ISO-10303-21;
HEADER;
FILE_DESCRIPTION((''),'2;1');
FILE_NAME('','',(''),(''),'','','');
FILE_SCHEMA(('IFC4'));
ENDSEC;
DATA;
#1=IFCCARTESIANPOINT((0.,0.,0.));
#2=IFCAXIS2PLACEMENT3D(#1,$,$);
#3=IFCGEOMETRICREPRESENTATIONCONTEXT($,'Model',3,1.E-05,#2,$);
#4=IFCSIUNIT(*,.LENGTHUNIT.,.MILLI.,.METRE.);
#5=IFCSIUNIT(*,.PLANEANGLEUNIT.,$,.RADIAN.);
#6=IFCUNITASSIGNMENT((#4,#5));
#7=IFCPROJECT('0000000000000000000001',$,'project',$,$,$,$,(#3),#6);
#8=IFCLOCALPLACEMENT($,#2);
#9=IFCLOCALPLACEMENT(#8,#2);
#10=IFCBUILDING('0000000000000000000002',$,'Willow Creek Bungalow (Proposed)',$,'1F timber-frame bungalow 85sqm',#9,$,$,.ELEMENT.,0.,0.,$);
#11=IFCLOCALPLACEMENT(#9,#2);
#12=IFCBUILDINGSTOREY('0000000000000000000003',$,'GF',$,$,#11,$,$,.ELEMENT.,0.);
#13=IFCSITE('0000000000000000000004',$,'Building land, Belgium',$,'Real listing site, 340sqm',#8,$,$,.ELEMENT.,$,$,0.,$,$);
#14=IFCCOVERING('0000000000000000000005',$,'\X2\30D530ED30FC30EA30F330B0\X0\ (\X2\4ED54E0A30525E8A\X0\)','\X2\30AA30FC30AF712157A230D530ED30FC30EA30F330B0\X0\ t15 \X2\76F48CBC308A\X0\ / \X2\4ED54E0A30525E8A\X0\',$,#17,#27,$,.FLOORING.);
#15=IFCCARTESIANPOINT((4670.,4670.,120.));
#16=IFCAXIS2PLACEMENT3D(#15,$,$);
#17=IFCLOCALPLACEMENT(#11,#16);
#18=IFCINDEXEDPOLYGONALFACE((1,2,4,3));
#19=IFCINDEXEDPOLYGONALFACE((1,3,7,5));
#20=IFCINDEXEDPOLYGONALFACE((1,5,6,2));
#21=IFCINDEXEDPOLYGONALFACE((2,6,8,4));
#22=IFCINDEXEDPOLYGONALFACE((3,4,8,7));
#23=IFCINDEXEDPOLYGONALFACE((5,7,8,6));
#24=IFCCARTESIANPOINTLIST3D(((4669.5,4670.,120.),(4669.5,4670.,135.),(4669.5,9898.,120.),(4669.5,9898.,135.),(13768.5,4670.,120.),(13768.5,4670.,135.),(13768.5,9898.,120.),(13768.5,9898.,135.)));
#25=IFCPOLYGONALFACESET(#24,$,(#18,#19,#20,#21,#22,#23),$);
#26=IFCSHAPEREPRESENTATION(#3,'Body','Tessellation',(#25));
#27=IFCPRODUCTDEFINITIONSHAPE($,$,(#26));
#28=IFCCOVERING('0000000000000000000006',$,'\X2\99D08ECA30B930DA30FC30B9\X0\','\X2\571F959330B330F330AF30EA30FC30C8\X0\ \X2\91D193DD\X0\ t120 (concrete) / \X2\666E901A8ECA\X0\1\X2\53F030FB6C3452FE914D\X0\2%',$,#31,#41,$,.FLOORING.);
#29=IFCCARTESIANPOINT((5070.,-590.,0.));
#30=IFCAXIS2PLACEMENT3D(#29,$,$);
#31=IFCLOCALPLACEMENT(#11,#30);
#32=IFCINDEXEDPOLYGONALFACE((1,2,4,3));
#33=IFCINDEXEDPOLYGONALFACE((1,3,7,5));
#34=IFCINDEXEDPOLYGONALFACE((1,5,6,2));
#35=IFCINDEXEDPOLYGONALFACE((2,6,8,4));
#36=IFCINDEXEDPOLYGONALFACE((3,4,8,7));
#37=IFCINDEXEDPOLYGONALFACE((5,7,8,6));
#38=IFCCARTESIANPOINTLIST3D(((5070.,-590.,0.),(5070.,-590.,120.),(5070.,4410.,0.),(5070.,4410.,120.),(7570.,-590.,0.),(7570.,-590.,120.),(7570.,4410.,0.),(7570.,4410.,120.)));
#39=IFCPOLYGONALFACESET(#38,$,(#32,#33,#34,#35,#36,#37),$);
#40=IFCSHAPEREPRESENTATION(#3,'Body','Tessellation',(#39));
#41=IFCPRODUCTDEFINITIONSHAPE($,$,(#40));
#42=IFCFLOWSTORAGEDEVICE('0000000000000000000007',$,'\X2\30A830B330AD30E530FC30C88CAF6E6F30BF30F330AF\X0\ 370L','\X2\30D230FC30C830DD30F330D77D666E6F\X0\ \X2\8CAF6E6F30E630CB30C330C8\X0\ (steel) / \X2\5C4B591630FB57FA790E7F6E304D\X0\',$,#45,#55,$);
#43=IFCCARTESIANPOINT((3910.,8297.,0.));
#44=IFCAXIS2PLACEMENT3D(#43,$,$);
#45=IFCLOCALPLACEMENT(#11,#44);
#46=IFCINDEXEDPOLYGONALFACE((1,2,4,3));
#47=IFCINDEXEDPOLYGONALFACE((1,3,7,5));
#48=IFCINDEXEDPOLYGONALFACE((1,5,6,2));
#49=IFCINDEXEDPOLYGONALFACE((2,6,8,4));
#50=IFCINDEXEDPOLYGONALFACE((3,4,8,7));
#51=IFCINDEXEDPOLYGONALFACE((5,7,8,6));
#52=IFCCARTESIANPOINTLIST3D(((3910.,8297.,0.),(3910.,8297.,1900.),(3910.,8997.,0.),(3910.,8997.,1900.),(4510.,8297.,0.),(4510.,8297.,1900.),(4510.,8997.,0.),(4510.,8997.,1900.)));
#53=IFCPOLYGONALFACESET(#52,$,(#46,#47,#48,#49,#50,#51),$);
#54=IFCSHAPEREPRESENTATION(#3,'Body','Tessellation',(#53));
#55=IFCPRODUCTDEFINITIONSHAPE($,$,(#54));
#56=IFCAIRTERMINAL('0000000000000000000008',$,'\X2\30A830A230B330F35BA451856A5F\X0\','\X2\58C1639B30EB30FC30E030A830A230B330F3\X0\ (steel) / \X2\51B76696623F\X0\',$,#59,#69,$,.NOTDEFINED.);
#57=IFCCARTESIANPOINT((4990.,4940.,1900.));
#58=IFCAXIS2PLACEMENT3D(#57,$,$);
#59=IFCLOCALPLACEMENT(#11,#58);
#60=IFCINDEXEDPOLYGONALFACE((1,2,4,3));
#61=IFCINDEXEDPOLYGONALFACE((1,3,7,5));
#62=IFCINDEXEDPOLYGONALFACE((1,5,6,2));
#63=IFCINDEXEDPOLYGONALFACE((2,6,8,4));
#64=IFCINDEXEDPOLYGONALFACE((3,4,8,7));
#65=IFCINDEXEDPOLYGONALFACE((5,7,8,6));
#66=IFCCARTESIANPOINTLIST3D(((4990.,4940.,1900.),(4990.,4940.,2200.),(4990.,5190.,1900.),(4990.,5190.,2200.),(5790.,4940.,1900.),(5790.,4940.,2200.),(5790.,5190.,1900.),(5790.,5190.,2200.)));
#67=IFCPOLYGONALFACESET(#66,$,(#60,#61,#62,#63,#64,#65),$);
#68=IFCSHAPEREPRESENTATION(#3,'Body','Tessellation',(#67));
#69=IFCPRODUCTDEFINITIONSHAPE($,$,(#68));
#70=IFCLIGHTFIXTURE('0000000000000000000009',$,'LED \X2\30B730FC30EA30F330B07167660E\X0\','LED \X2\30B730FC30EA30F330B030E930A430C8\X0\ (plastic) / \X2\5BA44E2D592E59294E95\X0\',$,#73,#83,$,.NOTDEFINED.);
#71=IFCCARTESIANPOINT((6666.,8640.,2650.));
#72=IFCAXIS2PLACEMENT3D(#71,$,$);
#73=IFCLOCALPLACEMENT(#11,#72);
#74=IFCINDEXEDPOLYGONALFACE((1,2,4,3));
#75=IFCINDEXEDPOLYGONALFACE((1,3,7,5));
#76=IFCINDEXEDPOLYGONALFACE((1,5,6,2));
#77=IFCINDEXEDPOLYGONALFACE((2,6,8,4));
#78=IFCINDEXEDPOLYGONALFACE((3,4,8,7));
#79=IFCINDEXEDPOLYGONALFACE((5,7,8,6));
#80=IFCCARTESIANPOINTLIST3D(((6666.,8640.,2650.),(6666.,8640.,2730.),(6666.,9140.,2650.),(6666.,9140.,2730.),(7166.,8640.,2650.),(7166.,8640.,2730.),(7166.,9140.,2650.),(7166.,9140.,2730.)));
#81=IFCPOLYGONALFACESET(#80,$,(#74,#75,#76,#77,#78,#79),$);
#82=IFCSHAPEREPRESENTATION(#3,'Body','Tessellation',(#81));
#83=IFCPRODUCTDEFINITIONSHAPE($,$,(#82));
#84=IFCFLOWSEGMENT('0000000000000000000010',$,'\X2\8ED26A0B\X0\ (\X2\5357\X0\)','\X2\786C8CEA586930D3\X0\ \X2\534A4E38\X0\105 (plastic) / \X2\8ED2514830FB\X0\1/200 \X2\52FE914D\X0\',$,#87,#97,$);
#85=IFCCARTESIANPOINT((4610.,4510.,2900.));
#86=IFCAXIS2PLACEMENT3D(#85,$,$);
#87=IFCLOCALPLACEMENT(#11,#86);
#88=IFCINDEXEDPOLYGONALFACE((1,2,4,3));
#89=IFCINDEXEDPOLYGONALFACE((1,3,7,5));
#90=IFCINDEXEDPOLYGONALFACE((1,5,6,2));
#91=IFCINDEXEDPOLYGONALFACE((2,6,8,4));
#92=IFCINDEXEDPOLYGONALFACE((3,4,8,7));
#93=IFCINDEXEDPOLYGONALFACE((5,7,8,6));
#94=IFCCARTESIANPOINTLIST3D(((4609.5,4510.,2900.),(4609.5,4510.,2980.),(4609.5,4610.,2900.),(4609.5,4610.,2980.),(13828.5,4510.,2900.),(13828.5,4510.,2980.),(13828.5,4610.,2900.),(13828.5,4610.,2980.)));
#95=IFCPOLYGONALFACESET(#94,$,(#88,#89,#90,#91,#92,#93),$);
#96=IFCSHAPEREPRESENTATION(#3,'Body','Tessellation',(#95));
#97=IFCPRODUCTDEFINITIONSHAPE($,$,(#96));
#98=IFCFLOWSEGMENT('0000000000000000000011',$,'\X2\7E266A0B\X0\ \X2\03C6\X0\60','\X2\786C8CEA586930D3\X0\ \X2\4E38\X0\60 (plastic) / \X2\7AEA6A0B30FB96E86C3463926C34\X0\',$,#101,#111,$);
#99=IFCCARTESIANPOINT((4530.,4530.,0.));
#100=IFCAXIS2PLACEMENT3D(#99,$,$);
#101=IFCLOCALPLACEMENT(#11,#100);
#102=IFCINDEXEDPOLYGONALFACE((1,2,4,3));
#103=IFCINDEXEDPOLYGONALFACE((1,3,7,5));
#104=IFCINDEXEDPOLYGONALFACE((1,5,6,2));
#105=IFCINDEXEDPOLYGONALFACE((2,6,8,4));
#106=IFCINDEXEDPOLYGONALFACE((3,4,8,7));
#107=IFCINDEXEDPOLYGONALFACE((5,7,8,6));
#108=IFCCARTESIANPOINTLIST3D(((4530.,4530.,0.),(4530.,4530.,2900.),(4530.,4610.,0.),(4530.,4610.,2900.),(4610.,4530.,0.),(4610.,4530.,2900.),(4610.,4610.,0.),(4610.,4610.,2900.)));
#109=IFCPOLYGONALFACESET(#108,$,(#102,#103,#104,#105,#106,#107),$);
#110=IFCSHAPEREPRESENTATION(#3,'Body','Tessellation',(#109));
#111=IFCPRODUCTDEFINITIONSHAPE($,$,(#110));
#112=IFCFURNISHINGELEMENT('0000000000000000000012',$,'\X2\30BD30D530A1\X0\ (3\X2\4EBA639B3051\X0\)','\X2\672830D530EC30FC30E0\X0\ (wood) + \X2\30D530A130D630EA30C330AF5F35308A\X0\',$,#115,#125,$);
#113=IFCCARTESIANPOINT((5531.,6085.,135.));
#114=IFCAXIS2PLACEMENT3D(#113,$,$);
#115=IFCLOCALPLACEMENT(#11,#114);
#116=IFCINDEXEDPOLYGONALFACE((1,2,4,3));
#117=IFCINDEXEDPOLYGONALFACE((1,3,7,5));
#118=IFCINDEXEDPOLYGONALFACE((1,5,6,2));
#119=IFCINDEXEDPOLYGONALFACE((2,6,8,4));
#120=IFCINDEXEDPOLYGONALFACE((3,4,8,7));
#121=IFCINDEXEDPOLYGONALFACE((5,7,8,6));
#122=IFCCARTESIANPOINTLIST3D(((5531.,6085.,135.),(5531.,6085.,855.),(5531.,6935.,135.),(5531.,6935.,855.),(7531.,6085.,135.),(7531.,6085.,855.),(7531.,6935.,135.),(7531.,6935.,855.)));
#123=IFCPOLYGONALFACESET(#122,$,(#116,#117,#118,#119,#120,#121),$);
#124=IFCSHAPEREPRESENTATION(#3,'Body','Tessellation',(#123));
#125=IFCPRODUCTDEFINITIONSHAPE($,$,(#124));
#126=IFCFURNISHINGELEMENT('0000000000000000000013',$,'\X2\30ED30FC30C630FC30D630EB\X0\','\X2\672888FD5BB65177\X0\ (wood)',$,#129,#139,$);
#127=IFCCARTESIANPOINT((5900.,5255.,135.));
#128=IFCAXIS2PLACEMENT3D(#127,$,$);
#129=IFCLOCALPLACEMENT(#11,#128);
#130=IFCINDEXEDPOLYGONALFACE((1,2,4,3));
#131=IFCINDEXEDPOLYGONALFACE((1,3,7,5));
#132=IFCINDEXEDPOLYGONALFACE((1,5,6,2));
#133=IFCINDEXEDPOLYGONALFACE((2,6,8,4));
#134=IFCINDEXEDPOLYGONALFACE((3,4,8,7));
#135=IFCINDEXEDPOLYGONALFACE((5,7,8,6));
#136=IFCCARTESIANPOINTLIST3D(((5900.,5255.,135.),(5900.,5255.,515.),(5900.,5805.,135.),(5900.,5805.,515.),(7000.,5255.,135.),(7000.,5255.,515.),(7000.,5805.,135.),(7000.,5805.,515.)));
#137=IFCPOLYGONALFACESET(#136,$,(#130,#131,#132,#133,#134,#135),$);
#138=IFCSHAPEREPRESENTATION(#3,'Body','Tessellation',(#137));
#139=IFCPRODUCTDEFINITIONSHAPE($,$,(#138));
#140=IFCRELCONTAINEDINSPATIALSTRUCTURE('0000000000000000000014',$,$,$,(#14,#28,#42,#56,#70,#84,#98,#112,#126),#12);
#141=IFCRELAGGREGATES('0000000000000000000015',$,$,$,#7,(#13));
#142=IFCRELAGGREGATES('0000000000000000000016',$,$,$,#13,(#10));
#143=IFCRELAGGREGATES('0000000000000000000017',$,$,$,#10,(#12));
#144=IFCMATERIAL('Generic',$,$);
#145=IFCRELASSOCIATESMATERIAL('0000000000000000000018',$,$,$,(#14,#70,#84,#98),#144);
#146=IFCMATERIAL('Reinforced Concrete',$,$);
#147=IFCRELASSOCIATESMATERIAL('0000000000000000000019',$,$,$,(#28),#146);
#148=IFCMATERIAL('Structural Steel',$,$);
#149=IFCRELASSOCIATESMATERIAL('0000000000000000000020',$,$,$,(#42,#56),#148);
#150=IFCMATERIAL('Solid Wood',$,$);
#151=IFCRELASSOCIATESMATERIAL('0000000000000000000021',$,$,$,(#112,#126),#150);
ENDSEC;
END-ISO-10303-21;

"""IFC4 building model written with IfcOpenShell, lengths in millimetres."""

from ifc_helpers import new_model, si_unit, frame, frame_2d, origin, place, context, project, spatial, rectangle, extrude, material, element, save


model = new_model("IFC4")

# Units and contexts
model_context = context("Model", 3, precision=1e-05, world=origin())
ifc_project = project(units=[si_unit("LENGTHUNIT", "METRE", prefix="MILLI"), si_unit("PLANEANGLEUNIT", "RADIAN")], contexts=[model_context])

# Site, building, storey
site_placement = place(None, origin())
site = spatial("IfcSite", under=ifc_project, at=site_placement, Name="Building land, Belgium", ObjectType="Real listing site, 340sqm", CompositionType="ELEMENT", RefElevation=0.0)
building_placement = place(site_placement, origin())
building = spatial("IfcBuilding", under=site, at=building_placement, Name="Willow Creek Bungalow (Proposed)", ObjectType="1F timber-frame bungalow 85sqm", CompositionType="ELEMENT", ElevationOfRefHeight=0.0, ElevationOfTerrain=0.0)
storey_placement = place(building_placement, origin())
storey = spatial("IfcBuildingStorey", under=building, at=storey_placement, Name="GF", CompositionType="ELEMENT", Elevation=0.0)

# Shared definitions
ifc_material_1 = material(Name="Solid Wood")

# Shared definitions
ifc_material_2 = material(Name="Reinforced Concrete")

# Shared definitions
ifc_material_3 = material(Name="Structural Steel")

# Coverings
ifc_material_4 = material(Name="Generic")
covering_1_placement = place(storey_placement, frame((4670.0, 4670.0, 120.0)))
element("IfcCovering", 1, at=covering_1_placement, inside=storey, material=ifc_material_4, Name="フローリング (仕上げ床)", Description="オーク無垢フローリング t15 直貼り / 仕上げ床", PredefinedType="FLOORING", context=model_context, shape_type="SweptSolid", body=[
    extrude(rectangle(XDim=9099.0, YDim=5228.0, at=frame_2d((4549.0, 2614.0))), frame((4670.0, 4670.0, 120.0)), (0.0, 0.0, 1.0), 15.0),
])
covering_2_placement = place(storey_placement, frame((5070.0, -590.0, 0.0)))
element("IfcCovering", 2, at=covering_2_placement, inside=storey, material=ifc_material_2, Name="駐車スペース", Description="土間コンクリート 金鏝 t120 (concrete) / 普通車1台・水勾配2%", PredefinedType="FLOORING", context=model_context, shape_type="SweptSolid", body=[
    extrude(rectangle(XDim=2500.0, YDim=5000.0, at=frame_2d((1250.0, 2500.0))), frame((5070.0, -590.0, 0.0)), (0.0, 0.0, 1.0), 120.0),
])

# Flow storage device
flow_storage_device_placement = place(storey_placement, frame((3910.0, 8297.0, 0.0)))
element("IfcFlowStorageDevice", 3, at=flow_storage_device_placement, inside=storey, material=ifc_material_3, Name="エコキュート貯湯タンク 370L", Description="ヒートポンプ給湯 貯湯ユニット (steel) / 屋外・基礎置き", context=model_context, shape_type="SweptSolid", body=[
    extrude(rectangle(XDim=600.0, YDim=700.0, at=frame_2d((300.0, 350.0))), frame((3910.0, 8297.0, 0.0)), (0.0, 0.0, 1.0), 1900.0),
])

# Air terminal
air_terminal_placement = place(storey_placement, frame((4990.0, 4940.0, 1900.0)))
element("IfcAirTerminal", 4, at=air_terminal_placement, inside=storey, material=ifc_material_3, Name="エアコン室内機", Description="壁掛ルームエアコン (steel) / 冷暖房", PredefinedType="NOTDEFINED", context=model_context, shape_type="SweptSolid", body=[
    extrude(rectangle(XDim=800.0, YDim=250.0, at=frame_2d((400.0, 125.0))), frame((4990.0, 4940.0, 1900.0)), (0.0, 0.0, 1.0), 300.0),
])

# Light fixture
light_fixture_placement = place(storey_placement, frame((6666.0, 8640.0, 2650.0)))
element("IfcLightFixture", 5, at=light_fixture_placement, inside=storey, material=ifc_material_4, Name="LED シーリング照明", Description="LED シーリングライト (plastic) / 室中央天井", PredefinedType="NOTDEFINED", context=model_context, shape_type="SweptSolid", body=[
    extrude(rectangle(XDim=500.0, YDim=500.0, at=frame_2d((250.0, 250.0))), frame((6666.0, 8640.0, 2650.0)), (0.0, 0.0, 1.0), 80.0),
])

# Flow segments
flow_segment_1_placement = place(storey_placement, frame((4610.0, 4510.0, 2900.0)))
element("IfcFlowSegment", 6, at=flow_segment_1_placement, inside=storey, material=ifc_material_4, Name="軒樋 (南)", Description="硬質塩ビ 半丸105 (plastic) / 軒先・1/200 勾配", context=model_context, shape_type="SweptSolid", body=[
    extrude(rectangle(XDim=9219.0, YDim=100.0, at=frame_2d((4609.0, 50.0))), frame((4610.0, 4510.0, 2900.0)), (0.0, 0.0, 1.0), 80.0),
])
flow_segment_2_placement = place(storey_placement, frame((4530.0, 4530.0, 0.0)))
element("IfcFlowSegment", 7, at=flow_segment_2_placement, inside=storey, material=ifc_material_4, Name="縦樋 φ60", Description="硬質塩ビ 丸60 (plastic) / 竪樋・雨水排水", context=model_context, shape_type="SweptSolid", body=[
    extrude(rectangle(XDim=80.0, YDim=80.0, at=frame_2d((40.0, 40.0))), frame((4530.0, 4530.0, 0.0)), (0.0, 0.0, 1.0), 2900.0),
])

# Furnishing elements
furnishing_1_placement = place(storey_placement, frame((5531.0, 6085.0, 135.0)))
element("IfcFurnishingElement", 8, at=furnishing_1_placement, inside=storey, material=ifc_material_1, Name="ソファ (3人掛け)", Description="木フレーム (wood) + ファブリック張り", context=model_context, shape_type="SweptSolid", body=[
    extrude(rectangle(XDim=2000.0, YDim=850.0, at=frame_2d((1000.0, 425.0))), frame((5531.0, 6085.0, 135.0)), (0.0, 0.0, 1.0), 720.0),
])
furnishing_2_placement = place(storey_placement, frame((5900.0, 5255.0, 135.0)))
element("IfcFurnishingElement", 9, at=furnishing_2_placement, inside=storey, material=ifc_material_1, Name="ローテーブル", Description="木製家具 (wood)", context=model_context, shape_type="SweptSolid", body=[
    extrude(rectangle(XDim=1100.0, YDim=550.0, at=frame_2d((550.0, 275.0))), frame((5900.0, 5255.0, 135.0)), (0.0, 0.0, 1.0), 380.0),
])

save(model, "model.ifc")
